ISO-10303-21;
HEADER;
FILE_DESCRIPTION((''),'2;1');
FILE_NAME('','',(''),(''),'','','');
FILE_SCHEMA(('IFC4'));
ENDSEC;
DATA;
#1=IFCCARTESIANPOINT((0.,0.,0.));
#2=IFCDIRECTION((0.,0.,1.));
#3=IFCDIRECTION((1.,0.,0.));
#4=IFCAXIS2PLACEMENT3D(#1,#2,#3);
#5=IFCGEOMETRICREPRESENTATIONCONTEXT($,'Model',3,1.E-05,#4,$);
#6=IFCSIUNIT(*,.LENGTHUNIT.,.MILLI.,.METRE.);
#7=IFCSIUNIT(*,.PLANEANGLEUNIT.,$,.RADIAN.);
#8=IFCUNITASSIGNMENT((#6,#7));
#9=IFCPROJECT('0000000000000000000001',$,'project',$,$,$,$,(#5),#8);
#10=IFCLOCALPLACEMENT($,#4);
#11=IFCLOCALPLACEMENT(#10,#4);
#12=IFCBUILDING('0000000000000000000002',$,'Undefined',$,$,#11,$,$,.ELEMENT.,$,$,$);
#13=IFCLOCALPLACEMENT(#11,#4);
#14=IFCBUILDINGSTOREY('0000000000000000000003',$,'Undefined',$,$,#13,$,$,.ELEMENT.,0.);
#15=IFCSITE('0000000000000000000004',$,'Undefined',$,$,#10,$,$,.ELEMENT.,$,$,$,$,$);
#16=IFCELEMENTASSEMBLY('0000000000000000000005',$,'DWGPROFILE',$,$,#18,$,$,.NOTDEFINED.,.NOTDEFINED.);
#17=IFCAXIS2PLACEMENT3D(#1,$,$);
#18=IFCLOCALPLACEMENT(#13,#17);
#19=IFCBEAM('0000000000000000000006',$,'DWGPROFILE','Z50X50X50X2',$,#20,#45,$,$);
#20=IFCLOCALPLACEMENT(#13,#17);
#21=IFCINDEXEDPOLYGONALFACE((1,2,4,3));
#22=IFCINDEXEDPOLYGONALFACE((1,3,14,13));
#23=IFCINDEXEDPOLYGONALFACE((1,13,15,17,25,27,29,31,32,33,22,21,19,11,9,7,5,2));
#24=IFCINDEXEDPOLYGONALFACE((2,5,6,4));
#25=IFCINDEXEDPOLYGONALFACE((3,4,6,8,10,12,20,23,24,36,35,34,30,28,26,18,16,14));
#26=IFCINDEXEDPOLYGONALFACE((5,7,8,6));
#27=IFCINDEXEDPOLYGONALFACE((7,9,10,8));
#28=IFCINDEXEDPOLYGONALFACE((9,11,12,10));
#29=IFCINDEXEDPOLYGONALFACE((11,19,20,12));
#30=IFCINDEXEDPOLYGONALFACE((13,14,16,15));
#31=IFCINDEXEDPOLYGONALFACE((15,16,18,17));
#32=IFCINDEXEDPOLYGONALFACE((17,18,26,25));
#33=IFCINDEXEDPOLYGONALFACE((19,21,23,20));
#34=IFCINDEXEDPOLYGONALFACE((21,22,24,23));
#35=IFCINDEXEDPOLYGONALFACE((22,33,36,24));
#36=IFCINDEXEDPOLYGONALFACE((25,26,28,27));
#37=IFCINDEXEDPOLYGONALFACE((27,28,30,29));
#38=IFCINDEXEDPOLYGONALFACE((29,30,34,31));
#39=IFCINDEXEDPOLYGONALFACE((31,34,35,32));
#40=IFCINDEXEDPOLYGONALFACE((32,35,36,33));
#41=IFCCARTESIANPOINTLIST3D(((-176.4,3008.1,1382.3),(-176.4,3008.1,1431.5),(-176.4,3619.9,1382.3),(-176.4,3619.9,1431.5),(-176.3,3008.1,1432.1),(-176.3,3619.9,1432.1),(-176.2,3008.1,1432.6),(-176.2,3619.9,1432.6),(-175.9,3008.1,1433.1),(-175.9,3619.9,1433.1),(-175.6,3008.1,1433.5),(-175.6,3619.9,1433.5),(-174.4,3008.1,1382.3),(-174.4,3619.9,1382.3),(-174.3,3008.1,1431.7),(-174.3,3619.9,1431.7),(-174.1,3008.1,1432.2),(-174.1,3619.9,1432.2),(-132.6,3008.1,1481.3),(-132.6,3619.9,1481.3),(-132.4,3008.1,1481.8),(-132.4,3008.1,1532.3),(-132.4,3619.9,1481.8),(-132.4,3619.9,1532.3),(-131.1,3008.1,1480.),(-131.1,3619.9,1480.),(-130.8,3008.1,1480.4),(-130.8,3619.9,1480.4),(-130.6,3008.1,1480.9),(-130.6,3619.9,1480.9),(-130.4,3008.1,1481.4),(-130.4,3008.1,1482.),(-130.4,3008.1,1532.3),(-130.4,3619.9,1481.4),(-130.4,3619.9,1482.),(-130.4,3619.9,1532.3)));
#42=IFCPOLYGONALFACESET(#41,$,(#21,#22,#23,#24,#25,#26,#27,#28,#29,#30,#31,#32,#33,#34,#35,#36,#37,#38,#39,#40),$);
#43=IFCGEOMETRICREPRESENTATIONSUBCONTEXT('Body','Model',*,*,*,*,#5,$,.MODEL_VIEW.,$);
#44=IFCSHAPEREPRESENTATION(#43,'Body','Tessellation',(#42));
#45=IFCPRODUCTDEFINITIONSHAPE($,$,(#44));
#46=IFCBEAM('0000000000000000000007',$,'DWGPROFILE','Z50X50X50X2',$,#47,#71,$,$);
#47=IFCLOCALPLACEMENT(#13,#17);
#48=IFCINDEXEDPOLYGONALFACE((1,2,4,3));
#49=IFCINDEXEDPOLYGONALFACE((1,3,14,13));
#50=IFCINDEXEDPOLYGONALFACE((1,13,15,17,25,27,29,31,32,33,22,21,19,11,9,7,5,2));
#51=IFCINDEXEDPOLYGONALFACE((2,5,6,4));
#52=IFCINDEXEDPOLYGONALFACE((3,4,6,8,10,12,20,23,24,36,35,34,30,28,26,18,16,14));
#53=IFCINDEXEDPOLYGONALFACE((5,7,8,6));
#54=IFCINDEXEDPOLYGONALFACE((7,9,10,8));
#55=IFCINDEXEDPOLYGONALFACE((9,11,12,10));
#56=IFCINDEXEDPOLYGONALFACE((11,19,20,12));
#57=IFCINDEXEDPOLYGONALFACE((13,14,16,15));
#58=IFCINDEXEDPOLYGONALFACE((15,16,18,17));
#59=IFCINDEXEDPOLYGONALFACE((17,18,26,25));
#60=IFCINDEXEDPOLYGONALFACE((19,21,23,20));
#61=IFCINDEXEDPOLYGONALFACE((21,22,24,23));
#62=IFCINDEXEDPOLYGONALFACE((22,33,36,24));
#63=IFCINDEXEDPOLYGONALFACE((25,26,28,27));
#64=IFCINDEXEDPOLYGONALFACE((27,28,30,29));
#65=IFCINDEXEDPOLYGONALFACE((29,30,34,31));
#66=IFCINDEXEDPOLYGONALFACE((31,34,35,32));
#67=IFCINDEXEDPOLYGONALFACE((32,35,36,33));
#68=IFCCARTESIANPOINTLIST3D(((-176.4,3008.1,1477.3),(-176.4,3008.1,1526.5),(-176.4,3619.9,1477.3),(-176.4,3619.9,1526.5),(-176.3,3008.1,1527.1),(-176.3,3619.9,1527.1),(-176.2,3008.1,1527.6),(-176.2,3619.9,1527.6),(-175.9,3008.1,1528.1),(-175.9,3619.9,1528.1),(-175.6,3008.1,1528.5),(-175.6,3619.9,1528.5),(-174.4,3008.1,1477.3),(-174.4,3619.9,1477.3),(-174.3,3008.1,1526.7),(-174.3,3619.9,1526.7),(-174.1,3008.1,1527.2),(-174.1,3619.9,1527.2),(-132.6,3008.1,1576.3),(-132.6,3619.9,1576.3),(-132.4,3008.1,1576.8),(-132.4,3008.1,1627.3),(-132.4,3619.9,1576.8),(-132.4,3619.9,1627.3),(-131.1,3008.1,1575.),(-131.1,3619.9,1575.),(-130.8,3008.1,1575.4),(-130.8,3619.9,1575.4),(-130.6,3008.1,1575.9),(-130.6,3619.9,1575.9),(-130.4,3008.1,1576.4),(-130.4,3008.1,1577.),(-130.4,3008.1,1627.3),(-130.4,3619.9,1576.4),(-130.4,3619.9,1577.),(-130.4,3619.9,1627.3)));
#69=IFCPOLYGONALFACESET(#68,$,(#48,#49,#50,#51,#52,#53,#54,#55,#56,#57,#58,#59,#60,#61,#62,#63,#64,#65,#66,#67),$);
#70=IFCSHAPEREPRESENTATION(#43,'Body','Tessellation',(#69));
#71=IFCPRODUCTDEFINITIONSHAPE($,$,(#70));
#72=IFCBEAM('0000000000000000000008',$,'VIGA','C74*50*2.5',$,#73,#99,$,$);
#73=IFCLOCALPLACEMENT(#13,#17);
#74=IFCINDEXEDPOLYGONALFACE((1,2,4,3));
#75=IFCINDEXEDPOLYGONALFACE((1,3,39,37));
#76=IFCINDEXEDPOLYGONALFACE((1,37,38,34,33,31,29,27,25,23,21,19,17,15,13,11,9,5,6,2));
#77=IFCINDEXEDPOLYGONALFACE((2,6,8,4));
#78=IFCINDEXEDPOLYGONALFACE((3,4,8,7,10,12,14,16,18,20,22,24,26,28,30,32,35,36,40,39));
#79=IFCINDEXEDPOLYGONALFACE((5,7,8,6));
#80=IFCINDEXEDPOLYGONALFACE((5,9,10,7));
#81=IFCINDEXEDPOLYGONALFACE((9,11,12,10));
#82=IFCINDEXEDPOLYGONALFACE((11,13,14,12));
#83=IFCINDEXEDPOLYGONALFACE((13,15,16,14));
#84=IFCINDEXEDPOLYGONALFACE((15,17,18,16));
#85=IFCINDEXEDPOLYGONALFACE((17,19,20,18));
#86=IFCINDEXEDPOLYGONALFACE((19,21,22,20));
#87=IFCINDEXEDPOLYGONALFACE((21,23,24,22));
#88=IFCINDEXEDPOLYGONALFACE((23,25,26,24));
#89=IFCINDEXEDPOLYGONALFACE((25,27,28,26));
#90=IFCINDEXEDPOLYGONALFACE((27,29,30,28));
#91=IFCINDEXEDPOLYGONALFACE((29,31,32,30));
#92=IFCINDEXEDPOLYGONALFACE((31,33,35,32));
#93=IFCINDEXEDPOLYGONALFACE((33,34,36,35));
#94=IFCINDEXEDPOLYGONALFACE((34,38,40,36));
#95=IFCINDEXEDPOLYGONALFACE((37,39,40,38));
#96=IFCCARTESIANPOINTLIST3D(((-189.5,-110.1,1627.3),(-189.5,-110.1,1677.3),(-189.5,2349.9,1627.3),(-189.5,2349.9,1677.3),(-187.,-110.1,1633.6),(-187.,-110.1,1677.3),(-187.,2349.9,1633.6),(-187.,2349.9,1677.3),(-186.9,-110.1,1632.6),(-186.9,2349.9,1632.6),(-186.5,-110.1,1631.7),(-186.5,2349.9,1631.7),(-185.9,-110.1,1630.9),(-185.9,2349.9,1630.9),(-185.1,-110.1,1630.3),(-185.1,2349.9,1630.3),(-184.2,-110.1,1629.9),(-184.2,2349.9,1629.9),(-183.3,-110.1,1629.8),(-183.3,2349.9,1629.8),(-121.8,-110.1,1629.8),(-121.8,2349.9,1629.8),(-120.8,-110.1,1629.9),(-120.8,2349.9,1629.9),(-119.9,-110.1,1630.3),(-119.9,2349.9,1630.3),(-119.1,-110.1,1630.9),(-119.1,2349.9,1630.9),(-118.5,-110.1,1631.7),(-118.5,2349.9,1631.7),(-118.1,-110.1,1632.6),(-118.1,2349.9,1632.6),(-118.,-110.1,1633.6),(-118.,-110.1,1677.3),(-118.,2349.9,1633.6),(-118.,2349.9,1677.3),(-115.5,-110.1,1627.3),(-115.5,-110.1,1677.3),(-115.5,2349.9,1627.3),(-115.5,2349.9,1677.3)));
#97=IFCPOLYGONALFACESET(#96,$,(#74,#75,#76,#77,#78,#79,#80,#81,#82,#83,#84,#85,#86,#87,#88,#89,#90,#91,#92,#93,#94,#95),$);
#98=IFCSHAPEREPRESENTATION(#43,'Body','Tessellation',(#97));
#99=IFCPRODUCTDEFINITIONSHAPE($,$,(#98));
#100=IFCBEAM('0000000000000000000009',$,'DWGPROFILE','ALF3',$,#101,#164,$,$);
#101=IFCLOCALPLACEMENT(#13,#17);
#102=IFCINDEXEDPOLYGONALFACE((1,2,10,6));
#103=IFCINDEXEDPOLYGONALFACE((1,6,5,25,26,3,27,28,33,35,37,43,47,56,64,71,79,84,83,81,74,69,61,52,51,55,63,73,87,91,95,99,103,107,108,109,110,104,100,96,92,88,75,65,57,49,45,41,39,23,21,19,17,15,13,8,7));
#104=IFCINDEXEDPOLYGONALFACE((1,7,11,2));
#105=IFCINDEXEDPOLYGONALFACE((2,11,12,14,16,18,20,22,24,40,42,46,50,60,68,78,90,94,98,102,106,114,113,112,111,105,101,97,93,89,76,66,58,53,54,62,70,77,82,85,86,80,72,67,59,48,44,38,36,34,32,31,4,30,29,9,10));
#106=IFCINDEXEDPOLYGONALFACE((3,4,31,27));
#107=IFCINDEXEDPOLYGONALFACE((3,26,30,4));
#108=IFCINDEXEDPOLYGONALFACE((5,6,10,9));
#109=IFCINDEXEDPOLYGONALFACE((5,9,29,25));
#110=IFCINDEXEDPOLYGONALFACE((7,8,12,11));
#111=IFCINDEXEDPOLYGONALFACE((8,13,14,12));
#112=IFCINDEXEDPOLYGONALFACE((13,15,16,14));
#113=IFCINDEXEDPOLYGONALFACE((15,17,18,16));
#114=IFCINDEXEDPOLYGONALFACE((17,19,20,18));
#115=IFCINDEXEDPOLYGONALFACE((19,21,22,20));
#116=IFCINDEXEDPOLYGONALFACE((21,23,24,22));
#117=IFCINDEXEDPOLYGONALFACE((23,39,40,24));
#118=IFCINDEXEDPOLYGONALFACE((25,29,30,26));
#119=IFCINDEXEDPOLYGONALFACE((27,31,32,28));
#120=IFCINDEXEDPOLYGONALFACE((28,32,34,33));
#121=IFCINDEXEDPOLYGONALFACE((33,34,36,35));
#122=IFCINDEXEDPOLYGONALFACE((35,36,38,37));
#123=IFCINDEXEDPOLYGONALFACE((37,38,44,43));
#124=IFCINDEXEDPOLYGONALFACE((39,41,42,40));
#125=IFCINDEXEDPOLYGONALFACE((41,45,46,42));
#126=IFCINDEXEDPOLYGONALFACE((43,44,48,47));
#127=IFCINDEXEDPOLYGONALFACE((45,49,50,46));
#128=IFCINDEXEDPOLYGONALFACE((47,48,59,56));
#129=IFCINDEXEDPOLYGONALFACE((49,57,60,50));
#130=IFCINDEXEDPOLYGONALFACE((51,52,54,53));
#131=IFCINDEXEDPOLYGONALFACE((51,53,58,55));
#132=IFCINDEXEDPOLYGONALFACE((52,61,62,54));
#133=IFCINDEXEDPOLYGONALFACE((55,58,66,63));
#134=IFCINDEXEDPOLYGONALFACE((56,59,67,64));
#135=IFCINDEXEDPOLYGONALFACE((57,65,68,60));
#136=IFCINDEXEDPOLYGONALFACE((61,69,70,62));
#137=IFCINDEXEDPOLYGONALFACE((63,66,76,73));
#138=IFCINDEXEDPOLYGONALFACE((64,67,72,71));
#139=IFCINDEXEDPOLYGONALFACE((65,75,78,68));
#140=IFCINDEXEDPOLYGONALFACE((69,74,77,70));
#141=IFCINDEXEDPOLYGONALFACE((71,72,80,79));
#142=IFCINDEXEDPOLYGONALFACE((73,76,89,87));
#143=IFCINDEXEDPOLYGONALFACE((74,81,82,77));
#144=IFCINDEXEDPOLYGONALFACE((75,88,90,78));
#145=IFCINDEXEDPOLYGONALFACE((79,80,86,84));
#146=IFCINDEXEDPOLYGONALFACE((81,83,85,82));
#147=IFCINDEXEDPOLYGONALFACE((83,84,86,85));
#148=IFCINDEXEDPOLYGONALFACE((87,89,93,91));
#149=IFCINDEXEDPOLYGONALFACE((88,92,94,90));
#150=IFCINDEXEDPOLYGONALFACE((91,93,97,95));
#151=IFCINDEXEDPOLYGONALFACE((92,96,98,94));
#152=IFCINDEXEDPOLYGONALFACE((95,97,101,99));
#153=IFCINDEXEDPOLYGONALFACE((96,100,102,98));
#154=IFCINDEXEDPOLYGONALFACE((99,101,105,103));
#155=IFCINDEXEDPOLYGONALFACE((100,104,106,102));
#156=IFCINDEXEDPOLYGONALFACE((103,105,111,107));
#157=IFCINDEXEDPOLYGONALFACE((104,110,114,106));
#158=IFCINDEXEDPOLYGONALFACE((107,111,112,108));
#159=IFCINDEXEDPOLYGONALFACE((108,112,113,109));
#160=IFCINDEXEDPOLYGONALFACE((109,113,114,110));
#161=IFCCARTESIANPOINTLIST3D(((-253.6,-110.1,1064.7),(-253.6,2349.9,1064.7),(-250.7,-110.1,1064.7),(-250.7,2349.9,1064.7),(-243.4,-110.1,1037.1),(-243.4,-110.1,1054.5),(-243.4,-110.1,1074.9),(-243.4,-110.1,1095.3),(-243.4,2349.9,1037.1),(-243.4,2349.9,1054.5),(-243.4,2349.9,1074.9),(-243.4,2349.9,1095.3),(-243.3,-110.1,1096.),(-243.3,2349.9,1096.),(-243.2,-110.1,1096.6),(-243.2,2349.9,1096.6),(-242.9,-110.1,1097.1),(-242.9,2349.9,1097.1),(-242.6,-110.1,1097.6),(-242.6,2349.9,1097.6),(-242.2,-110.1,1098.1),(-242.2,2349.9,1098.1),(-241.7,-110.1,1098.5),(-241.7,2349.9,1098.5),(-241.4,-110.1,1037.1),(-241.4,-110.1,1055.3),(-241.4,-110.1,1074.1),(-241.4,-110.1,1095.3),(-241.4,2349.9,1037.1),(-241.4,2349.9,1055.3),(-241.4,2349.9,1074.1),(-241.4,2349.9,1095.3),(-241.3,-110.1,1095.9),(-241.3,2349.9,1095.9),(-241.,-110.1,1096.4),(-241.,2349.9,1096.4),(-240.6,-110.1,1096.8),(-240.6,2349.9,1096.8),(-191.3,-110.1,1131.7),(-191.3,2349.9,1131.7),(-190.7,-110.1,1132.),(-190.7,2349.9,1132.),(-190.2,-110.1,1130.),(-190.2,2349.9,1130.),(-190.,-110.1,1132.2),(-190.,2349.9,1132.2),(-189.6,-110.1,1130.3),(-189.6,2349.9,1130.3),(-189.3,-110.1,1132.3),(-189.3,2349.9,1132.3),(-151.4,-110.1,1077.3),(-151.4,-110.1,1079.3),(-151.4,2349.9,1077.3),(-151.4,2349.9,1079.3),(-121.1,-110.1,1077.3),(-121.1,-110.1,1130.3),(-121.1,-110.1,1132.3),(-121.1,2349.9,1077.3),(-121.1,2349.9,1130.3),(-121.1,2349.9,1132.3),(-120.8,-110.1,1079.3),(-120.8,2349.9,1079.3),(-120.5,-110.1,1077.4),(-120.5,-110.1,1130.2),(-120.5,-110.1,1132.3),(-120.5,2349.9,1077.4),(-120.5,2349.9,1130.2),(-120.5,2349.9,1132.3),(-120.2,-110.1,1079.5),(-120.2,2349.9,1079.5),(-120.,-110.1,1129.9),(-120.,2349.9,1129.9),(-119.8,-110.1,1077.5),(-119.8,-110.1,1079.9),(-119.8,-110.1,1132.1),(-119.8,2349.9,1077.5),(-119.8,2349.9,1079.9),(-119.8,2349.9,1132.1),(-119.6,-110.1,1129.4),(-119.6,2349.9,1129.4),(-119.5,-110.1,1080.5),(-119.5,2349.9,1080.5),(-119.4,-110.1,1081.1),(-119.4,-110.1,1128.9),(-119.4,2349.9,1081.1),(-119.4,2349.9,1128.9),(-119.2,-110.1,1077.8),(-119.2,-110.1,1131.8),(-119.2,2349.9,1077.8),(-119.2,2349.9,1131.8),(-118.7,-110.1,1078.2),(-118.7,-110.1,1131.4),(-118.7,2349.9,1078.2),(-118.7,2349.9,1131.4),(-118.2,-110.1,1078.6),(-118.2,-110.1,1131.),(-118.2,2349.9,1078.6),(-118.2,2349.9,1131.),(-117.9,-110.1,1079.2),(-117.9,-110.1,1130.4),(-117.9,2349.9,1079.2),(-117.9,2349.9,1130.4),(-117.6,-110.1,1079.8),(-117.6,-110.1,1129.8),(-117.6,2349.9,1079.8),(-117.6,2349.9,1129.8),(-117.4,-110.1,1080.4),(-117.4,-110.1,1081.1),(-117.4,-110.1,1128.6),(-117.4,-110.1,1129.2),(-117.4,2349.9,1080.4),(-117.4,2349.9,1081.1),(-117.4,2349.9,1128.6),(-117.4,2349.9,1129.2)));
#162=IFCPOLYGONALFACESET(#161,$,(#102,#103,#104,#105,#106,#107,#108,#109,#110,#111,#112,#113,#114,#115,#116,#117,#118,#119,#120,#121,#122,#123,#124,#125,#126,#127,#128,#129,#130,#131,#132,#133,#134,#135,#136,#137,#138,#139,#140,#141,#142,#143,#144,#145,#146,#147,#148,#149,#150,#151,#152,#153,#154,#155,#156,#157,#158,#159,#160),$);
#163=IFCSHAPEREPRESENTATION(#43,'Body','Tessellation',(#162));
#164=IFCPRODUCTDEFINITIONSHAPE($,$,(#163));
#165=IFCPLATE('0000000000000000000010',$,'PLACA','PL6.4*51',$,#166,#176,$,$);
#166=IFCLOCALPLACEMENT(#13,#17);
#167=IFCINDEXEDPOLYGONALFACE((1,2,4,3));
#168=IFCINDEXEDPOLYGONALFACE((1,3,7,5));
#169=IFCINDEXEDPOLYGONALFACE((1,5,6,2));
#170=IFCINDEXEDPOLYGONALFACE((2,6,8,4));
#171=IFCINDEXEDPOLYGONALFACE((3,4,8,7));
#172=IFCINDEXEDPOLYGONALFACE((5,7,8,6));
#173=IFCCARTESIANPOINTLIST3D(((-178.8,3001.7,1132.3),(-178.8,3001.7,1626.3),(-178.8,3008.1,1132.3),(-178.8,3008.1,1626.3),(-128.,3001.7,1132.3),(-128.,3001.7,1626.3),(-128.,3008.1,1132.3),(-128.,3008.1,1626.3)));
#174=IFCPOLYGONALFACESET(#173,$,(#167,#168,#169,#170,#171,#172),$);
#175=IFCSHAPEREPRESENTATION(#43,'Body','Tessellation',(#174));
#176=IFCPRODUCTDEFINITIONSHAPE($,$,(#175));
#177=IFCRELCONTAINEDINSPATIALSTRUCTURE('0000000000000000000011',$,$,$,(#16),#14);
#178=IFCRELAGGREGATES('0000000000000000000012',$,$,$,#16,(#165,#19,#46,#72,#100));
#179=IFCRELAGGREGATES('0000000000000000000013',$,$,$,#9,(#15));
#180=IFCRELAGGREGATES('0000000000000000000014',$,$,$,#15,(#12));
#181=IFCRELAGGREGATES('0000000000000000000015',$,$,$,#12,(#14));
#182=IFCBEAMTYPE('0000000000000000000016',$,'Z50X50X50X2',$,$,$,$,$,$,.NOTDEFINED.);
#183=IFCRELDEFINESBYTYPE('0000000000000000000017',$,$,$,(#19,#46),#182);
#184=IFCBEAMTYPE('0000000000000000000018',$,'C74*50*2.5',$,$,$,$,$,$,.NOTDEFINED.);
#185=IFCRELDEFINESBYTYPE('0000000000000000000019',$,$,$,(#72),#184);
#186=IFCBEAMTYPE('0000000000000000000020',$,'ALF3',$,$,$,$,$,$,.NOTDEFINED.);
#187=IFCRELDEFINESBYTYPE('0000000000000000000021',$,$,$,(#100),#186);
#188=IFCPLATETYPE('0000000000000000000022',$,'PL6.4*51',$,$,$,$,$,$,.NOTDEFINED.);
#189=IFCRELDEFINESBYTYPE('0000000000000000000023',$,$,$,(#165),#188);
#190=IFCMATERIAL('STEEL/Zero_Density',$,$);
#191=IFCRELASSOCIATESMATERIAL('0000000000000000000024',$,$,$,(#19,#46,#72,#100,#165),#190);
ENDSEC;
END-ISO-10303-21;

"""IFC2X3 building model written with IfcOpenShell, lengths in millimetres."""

from ifc_helpers import new_model, si_unit, frame, origin_with_axes, origin_2d_with_axis, place, context, subcontext, project, spatial, polyline, u_section, outline, extrude, material, type_object, element, aggregate, save


model = new_model("IFC2X3")

# Units and contexts
model_context = context("Model", 3, precision=1e-05, world=origin_with_axes())
body_context = subcontext(model_context, "Body", "Model", "MODEL_VIEW")
ifc_project = project(units=[si_unit("LENGTHUNIT", "METRE", prefix="MILLI"), si_unit("PLANEANGLEUNIT", "RADIAN")], contexts=[model_context])

# Site, building, storey
site_placement = place(None, origin_with_axes())
site = spatial("IfcSite", under=ifc_project, at=site_placement, Name="Undefined", CompositionType="ELEMENT")
building_placement = place(site_placement, origin_with_axes())
building = spatial("IfcBuilding", under=site, at=building_placement, Name="Undefined", CompositionType="ELEMENT")
storey_placement = place(building_placement, origin_with_axes())
storey = spatial("IfcBuildingStorey", under=building, at=storey_placement, Name="Undefined", CompositionType="ELEMENT", Elevation=0.0)

# Element assembly, beams, plate
assembly_1_placement = place(storey_placement, origin_with_axes())
assembly_1 = element("IfcElementAssembly", 1, at=assembly_1_placement, inside=storey, Name="DWGPROFILE", AssemblyPlace="NOTDEFINED", PredefinedType="NOTDEFINED")
ifc_material_1 = material(Name="STEEL/Zero_Density")
beam_type_1 = type_object("IfcBeamType", Name="Z50X50X50X2", PredefinedType="NOTDEFINED")
beam_1_placement = place(assembly_1_placement, frame((-153.4, 3619.9, 1457.3), z_axis=(0.0, 0.0, 1.0), x_axis=(0.0, -1.0, 0.0)))
beam_1 = element("IfcBeam", 2, at=beam_1_placement, type_object=beam_type_1, material=ifc_material_1, Name="DWGPROFILE", Description="Z50X50X50X2", context=body_context, shape_type="SweptSolid", body=[
    extrude(outline(polyline([(-22.9, 24.1), (-23.0, 24.7), (-23.0, 75.0), (-21.0, 75.0), (-21.0, 24.5), (-20.7, 24.0), (22.2, -23.8), (22.6, -24.2), (22.8, -24.7), (22.9, -25.2), (23.0, -25.8), (23.0, -75.0), (21.0, -75.0), (21.0, -25.6), (20.7, -25.1), (-22.2, 22.6), (-22.6, 23.1), (-22.8, 23.6), (-22.9, 24.1)])), frame((611.8, 0.0, 0.0), z_axis=(-1.0, 0.0, 0.0), x_axis=(0.0, -1.0, 0.0)), (0.0, 0.0, 1.0), 611.8),
])
beam_2_placement = place(assembly_1_placement, frame((-153.4, 3619.9, 1552.3), z_axis=(0.0, 0.0, 1.0), x_axis=(0.0, -1.0, 0.0)))
beam_2 = element("IfcBeam", 3, at=beam_2_placement, type_object=beam_type_1, material=ifc_material_1, Name="DWGPROFILE", Description="Z50X50X50X2", context=body_context, shape_type="SweptSolid", body=[
    extrude(outline(polyline([(-22.9, 24.1), (-23.0, 24.7), (-23.0, 75.0), (-21.0, 75.0), (-21.0, 24.5), (-20.7, 24.0), (22.2, -23.8), (22.6, -24.2), (22.8, -24.7), (22.9, -25.2), (23.0, -25.8), (23.0, -75.0), (21.0, -75.0), (21.0, -25.6), (20.7, -25.1), (-22.2, 22.6), (-22.6, 23.1), (-22.8, 23.6), (-22.9, 24.1)])), frame((611.8, 0.0, 0.0), z_axis=(-1.0, 0.0, 0.0), x_axis=(0.0, -1.0, 0.0)), (0.0, 0.0, 1.0), 611.8),
])
beam_type_2 = type_object("IfcBeamType", Name="C74*50*2.5", PredefinedType="NOTDEFINED")
beam_3_placement = place(assembly_1_placement, frame((-152.5, 2349.9, 1652.3), z_axis=(1.0, 0.0, 0.0), x_axis=(0.0, -1.0, 0.0)))
beam_3 = element("IfcBeam", 4, at=beam_3_placement, type_object=beam_type_2, material=ifc_material_1, Name="VIGA", Description="C74*50*2.5", context=body_context, shape_type="SweptSolid", body=[
    extrude(u_section(Depth=74.0, FlangeWidth=50.0, WebThickness=2.5, FlangeThickness=2.5, FilletRadius=3.8, at=origin_2d_with_axis()), frame((2460.0, 0.0, 0.0), z_axis=(-1.0, 0.0, 0.0), x_axis=(0.0, -1.0, 0.0)), (0.0, 0.0, 1.0), 2460.0),
])
beam_type_3 = type_object("IfcBeamType", Name="ALF3", PredefinedType="NOTDEFINED")
beam_4_placement = place(assembly_1_placement, frame((-185.5, 2349.9, 1084.7), z_axis=(0.0, 0.0, 1.0), x_axis=(0.0, -1.0, 0.0)))
beam_4 = element("IfcBeam", 5, at=beam_4_placement, type_object=beam_type_3, material=ifc_material_1, Name="DWGPROFILE", Description="ALF3", context=body_context, shape_type="SweptSolid", body=[
    extrude(outline(polyline([(57.9, 10.6), (57.9, -9.8), (68.1, -20.0), (57.9, -30.2), (57.9, -47.6), (55.9, -47.6), (55.9, -29.4), (65.3, -20.0), (55.9, -10.6), (55.9, 10.6), (55.8, 11.2), (55.5, 11.7), (55.1, 12.1), (4.8, 45.3), (4.1, 45.6), (-64.3, 45.6), (-64.9, 45.5), (-65.5, 45.2), (-65.9, 44.7), (-66.1, 44.2), (-66.1, -3.6), (-66.0, -4.2), (-65.7, -4.8), (-65.2, -5.2), (-64.7, -5.4), (-34.1, -5.4), (-34.1, -7.4), (-64.3, -7.4), (-65.0, -7.3), (-65.6, -7.2), (-66.2, -6.9), (-66.8, -6.5), (-67.2, -6.1), (-67.6, -5.5), (-67.9, -4.9), (-68.0, -4.3), (-68.1, -3.6), (-68.1, 43.9), (-68.0, 44.5), (-67.9, 45.1), (-67.6, 45.7), (-67.2, 46.3), (-66.8, 46.7), (-66.2, 47.1), (-65.6, 47.4), (-65.0, 47.5), (-64.3, 47.6), (3.8, 47.6), (4.5, 47.5), (5.2, 47.3), (5.9, 47.0), (56.2, 13.8), (56.7, 13.4), (57.1, 12.9), (57.5, 12.4), (57.7, 11.9), (57.9, 11.3), (57.9, 10.6)])), frame((2460.0, 0.0, 0.0), z_axis=(-1.0, 0.0, 0.0), x_axis=(0.0, -1.0, 0.0)), (0.0, 0.0, 1.0), 2460.0),
])
plate_type_1 = type_object("IfcPlateType", Name="PL6.4*51", PredefinedType="NOTDEFINED")
plate_1_placement = place(assembly_1_placement, frame((-128.0, 3004.9, 1626.3), z_axis=(0.0, -1.0, 0.0), x_axis=(-1.0, 0.0, 0.0)))
plate_1 = element("IfcPlate", 6, at=plate_1_placement, type_object=plate_type_1, material=ifc_material_1, Name="PLACA", Description="PL6.4*51", context=body_context, shape_type="SweptSolid", body=[
    extrude(outline(polyline([(0.0, 0.0), (50.8, 0.0), (50.8, 494.0), (0.0, 494.0), (0.0, 0.0)])), frame((0.0, 0.0, -3.2), z_axis=(0.0, 0.0, 1.0), x_axis=(1.0, 0.0, 0.0)), (0.0, 0.0, 1.0), 6.4),
])
aggregate(assembly_1, [plate_1, beam_1, beam_2, beam_3, beam_4])

save(model, "model.ifc")
